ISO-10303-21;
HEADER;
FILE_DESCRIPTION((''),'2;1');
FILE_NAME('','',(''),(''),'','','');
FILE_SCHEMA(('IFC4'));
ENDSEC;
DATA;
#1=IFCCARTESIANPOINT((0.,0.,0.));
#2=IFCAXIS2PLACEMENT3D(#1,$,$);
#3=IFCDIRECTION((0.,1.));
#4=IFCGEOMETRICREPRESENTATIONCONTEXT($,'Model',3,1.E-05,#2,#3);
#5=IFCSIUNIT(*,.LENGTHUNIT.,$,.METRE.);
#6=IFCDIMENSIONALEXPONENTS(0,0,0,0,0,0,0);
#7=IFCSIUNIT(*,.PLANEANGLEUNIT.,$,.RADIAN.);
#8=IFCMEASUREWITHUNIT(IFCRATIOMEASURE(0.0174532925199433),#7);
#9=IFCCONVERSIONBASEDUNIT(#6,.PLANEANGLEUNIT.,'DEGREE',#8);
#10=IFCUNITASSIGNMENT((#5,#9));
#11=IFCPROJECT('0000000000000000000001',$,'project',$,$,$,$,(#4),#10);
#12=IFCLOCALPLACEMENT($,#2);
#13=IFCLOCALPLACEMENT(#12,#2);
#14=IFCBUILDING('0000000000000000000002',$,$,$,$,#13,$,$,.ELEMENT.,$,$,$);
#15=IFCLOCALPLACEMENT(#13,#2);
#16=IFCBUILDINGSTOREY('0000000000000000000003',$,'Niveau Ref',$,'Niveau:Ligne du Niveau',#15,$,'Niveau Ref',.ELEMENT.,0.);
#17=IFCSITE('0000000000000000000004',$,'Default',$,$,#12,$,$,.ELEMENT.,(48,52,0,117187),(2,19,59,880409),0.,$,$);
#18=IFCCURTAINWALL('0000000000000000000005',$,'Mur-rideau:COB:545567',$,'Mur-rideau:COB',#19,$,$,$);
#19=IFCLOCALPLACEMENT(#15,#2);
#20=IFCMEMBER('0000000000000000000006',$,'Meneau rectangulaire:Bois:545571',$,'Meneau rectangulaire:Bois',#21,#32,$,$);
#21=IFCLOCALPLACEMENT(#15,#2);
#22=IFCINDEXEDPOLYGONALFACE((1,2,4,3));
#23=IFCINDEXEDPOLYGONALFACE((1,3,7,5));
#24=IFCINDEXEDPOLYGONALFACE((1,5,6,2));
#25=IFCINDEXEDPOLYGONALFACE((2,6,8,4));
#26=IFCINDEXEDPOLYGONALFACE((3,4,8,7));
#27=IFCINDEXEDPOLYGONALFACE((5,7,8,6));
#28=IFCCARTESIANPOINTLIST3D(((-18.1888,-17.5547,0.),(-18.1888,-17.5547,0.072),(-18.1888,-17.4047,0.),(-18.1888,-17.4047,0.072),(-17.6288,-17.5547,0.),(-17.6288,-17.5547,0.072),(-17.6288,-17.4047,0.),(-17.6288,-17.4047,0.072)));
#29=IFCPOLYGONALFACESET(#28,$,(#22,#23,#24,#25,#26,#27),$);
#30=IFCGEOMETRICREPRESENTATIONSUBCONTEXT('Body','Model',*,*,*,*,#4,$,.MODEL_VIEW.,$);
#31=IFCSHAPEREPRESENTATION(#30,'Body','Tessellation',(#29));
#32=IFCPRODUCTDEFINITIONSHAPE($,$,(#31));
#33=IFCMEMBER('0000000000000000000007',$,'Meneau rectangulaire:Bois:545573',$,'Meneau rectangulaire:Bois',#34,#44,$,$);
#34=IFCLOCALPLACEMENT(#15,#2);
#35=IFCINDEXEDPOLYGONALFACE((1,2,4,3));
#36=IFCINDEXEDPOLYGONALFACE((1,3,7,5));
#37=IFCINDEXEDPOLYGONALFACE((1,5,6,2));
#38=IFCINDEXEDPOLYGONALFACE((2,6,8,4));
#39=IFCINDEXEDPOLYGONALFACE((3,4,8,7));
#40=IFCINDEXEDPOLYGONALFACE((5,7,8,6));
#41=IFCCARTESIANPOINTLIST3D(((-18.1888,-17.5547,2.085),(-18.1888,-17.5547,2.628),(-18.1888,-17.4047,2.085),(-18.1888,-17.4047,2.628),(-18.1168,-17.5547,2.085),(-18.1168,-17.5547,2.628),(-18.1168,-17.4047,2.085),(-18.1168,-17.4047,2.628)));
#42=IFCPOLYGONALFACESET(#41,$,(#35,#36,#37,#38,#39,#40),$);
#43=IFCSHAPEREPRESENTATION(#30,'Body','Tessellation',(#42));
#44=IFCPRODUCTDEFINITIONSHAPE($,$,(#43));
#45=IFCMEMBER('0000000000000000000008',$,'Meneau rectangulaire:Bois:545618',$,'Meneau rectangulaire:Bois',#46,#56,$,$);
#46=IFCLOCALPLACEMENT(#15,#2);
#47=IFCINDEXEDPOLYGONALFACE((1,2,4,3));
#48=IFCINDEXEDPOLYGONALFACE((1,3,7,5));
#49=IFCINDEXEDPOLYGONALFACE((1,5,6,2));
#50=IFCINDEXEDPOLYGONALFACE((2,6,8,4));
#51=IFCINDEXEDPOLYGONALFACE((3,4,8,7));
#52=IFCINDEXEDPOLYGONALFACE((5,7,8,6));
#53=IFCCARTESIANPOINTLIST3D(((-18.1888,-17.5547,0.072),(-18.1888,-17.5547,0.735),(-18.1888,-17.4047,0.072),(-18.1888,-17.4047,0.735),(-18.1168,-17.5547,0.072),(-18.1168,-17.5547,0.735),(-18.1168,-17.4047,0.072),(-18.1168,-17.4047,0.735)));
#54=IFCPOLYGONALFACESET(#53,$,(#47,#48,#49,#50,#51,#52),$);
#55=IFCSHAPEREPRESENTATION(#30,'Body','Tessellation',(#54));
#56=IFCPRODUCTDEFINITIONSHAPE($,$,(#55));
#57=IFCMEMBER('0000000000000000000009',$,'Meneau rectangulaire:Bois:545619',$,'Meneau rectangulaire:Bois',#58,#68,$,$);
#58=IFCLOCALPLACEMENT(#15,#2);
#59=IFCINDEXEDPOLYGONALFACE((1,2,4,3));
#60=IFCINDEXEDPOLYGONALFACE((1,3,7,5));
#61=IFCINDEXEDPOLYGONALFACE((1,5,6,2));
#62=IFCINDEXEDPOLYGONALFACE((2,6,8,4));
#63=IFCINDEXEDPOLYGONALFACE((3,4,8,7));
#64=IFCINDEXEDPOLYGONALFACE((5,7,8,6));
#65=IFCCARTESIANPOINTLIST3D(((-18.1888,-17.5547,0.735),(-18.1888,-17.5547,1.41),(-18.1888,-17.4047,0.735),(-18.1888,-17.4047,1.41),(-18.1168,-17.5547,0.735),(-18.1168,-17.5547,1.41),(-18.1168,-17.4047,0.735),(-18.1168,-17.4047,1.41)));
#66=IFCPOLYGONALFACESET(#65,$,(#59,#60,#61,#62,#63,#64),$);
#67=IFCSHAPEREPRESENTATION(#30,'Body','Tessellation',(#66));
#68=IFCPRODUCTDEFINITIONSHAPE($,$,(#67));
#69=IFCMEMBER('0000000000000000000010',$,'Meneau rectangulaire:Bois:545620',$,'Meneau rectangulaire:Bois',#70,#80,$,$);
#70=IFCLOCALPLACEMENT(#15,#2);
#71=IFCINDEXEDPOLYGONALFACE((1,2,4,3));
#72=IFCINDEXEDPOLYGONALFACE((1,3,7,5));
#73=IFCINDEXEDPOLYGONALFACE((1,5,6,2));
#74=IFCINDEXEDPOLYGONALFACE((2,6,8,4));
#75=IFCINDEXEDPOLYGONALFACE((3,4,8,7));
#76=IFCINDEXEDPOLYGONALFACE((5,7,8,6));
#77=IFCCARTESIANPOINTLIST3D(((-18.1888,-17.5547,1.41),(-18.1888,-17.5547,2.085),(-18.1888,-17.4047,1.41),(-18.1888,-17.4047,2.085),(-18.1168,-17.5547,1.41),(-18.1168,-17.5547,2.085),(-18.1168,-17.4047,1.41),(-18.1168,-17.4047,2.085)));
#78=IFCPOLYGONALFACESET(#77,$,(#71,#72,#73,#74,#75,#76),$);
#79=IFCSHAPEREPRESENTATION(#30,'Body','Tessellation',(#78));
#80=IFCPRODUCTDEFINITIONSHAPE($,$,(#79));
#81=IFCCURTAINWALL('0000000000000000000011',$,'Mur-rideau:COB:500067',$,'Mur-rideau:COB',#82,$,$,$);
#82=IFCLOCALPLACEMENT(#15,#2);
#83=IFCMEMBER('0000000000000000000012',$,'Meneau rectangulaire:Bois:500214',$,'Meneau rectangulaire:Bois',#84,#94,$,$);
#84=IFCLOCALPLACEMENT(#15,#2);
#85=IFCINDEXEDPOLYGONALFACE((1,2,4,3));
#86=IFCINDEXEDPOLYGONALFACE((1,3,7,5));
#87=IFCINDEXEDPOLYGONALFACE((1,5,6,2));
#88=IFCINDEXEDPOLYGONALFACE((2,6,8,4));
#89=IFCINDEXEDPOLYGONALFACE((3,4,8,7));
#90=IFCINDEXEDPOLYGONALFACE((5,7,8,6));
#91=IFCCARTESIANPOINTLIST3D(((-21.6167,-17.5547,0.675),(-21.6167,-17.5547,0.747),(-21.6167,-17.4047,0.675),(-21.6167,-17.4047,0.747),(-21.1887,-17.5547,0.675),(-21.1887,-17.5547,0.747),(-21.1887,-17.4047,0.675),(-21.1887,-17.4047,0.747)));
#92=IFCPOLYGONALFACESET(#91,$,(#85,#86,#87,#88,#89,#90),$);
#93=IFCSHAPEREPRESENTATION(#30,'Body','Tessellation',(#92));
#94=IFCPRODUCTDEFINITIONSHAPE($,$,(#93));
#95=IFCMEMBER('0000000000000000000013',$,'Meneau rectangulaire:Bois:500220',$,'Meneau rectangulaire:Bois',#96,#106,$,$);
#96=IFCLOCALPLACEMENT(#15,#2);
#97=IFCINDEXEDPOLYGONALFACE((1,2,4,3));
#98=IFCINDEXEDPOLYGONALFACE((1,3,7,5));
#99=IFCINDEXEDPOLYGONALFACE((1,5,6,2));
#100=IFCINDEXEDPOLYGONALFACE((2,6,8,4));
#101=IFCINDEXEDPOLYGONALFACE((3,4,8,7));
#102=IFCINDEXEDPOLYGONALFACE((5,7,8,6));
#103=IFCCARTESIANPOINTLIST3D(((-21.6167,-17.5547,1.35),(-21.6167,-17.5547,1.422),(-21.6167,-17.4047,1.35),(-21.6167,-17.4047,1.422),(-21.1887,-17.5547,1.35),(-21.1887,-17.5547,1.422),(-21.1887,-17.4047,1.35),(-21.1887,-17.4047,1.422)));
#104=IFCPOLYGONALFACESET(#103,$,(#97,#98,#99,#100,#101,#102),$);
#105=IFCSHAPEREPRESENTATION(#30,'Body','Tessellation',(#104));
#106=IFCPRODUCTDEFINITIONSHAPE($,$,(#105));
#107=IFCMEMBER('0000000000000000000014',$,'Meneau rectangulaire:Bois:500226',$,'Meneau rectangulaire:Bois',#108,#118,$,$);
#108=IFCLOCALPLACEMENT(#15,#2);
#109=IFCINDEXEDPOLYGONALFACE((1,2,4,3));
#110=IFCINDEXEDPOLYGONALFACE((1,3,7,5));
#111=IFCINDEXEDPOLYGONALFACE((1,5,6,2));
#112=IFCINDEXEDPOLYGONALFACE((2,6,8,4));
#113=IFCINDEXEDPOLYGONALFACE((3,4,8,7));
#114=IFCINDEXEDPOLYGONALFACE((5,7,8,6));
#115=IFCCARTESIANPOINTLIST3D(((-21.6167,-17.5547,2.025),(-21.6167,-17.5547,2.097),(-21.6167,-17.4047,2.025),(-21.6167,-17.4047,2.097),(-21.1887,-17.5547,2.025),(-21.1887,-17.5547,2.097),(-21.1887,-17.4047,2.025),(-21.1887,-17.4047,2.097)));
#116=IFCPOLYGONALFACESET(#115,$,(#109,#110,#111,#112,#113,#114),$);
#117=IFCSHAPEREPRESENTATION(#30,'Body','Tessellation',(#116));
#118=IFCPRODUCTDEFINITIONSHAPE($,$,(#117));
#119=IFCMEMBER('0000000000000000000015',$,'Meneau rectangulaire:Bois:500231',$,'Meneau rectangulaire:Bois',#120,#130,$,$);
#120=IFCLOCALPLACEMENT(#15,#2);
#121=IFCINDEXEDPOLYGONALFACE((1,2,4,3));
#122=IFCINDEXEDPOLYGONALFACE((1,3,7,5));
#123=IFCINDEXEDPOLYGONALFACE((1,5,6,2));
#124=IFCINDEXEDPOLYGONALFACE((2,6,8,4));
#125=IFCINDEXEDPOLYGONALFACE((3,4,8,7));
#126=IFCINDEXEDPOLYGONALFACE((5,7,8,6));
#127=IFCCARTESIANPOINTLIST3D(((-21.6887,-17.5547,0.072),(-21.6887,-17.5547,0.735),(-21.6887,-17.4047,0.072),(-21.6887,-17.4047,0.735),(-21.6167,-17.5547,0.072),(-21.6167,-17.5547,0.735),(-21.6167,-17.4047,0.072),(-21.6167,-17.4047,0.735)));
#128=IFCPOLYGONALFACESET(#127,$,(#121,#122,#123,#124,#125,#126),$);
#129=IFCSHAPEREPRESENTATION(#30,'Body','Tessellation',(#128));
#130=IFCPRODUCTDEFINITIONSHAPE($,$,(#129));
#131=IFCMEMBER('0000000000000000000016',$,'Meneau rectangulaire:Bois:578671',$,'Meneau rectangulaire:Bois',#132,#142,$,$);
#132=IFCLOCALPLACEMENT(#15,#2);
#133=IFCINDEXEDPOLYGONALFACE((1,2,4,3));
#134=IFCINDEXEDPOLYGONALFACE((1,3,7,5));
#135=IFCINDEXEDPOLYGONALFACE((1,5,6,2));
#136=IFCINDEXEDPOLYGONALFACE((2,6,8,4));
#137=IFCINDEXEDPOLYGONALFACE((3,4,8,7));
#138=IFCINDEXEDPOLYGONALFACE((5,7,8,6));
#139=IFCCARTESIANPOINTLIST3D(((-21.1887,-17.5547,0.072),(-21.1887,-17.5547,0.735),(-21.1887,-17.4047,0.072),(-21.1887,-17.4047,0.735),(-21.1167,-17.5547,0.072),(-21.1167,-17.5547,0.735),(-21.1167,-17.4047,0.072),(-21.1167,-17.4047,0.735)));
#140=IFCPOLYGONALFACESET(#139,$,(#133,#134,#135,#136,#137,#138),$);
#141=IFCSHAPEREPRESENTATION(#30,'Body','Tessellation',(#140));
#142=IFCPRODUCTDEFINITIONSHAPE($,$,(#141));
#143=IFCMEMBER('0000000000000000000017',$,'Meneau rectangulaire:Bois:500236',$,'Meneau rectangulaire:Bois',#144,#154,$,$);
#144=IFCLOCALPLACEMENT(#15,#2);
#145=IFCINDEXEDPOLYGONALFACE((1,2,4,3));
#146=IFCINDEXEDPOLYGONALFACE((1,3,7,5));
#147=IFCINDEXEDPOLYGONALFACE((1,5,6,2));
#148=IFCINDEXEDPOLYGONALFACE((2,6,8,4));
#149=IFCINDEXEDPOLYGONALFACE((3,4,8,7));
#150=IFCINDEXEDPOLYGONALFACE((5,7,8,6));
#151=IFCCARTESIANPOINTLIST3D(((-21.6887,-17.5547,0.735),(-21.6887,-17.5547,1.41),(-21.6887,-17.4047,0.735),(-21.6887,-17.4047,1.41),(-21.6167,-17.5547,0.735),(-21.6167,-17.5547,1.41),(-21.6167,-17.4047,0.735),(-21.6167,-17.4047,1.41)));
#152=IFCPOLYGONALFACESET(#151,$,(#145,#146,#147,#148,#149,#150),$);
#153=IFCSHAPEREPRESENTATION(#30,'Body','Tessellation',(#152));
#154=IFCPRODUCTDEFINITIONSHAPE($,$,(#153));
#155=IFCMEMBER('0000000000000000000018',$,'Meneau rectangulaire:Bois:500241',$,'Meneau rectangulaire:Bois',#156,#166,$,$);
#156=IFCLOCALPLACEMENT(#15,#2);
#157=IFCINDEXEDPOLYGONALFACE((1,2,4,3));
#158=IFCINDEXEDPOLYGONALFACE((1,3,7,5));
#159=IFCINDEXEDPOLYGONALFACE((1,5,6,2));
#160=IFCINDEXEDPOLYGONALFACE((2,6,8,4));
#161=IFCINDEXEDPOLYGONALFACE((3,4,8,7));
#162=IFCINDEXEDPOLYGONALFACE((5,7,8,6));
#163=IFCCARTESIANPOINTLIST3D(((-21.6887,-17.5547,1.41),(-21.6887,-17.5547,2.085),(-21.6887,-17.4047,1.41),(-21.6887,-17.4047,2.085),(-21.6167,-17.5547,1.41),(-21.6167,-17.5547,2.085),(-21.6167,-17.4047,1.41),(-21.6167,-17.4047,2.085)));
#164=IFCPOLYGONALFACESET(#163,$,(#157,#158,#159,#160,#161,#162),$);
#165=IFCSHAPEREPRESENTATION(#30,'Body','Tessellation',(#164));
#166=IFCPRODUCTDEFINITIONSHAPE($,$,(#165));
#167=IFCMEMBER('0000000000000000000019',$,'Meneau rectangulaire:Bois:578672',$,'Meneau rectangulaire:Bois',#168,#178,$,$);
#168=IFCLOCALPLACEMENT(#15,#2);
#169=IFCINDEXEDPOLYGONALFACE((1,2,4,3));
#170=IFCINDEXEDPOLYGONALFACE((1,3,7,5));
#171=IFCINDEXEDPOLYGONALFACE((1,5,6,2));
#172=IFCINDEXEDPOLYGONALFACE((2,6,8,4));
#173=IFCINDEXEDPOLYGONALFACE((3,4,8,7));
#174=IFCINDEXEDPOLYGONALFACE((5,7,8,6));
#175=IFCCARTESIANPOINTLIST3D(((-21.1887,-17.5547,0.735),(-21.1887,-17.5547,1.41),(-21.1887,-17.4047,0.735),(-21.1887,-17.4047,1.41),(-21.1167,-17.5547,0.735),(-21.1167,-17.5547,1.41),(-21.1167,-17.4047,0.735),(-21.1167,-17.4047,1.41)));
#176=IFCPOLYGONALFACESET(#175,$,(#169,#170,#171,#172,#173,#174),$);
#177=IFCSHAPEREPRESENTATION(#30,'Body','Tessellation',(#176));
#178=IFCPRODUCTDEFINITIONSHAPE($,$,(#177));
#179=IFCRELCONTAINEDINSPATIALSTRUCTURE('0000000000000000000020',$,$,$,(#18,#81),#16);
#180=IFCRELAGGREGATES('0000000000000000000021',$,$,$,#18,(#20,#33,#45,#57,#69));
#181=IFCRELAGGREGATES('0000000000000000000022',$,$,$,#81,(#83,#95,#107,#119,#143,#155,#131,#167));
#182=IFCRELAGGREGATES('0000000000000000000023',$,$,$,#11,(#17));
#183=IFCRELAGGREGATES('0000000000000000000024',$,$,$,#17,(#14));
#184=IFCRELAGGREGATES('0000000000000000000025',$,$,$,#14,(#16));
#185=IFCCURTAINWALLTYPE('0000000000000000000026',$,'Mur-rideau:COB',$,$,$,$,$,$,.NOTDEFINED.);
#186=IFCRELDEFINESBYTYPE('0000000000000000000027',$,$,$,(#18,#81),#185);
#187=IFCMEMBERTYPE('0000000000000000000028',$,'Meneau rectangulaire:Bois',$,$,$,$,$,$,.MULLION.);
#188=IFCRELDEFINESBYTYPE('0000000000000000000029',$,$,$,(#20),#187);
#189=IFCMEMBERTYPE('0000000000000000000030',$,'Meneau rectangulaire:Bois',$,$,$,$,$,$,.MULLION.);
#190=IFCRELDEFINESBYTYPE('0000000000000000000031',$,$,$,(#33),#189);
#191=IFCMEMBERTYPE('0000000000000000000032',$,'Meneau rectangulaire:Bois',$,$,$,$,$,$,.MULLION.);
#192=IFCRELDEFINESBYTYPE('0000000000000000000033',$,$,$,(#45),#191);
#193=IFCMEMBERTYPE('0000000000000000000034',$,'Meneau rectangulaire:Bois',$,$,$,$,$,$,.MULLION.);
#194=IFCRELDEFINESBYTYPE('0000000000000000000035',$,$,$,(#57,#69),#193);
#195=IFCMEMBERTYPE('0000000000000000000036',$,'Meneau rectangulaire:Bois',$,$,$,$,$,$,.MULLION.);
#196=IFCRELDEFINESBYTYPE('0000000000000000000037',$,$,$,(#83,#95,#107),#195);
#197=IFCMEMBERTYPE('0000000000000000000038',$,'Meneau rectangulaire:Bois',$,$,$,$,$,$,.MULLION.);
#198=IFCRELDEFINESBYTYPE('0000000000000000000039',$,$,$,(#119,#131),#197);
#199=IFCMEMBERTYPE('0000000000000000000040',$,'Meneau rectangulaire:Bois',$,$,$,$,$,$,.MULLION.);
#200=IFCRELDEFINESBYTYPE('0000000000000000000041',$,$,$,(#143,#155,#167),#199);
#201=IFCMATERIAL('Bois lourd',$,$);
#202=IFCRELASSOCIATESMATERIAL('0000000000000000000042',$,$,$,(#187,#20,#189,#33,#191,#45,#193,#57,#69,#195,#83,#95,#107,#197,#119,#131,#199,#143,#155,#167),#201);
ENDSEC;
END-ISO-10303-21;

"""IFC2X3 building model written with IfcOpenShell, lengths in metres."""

from ifc_helpers import new_model, entity, si_unit, converted_unit, direction, frame, origin, origin_2d_with_axis, place, context, subcontext, project, spatial, rectangle, extrude, source, transform, mapped, material, type_object, type_shapes, element, aggregate, save


model = new_model("IFC2X3")

# Units and contexts
model_context = context("Model", 3, precision=1e-05, world=origin(), true_north=direction((0.0, 1.0)))
body_context = subcontext(model_context, "Body", "Model", "MODEL_VIEW")
ifc_project = project(units=[si_unit("LENGTHUNIT", "METRE"), converted_unit("PLANEANGLEUNIT", "DEGREE", entity("IfcRatioMeasure", 0.0174532925199433), si_unit("PLANEANGLEUNIT", "RADIAN"), dimensions=[0, 0, 0, 0, 0, 0, 0])], contexts=[model_context])

# Site, building, storey
site_placement = place(None, origin())
site = spatial("IfcSite", under=ifc_project, at=site_placement, Name="Default", CompositionType="ELEMENT", RefLatitude=(48, 52, 0, 117187), RefLongitude=(2, 19, 59, 880409), RefElevation=0.0)
building_placement = place(site_placement, origin())
building = spatial("IfcBuilding", under=site, at=building_placement, CompositionType="ELEMENT")
storey_placement = place(building_placement, origin())
storey = spatial("IfcBuildingStorey", under=building, at=storey_placement, Name="Niveau Ref", ObjectType="Niveau:Ligne du Niveau", LongName="Niveau Ref", CompositionType="ELEMENT", Elevation=0.0)

# Curtain walls, members
curtain_wall_type_1 = type_object("IfcCurtainWallType", Name="Mur-rideau:COB", PredefinedType="NOTDEFINED")
curtain_wall_1_placement = place(storey_placement, origin())
curtain_wall_1 = element("IfcCurtainWall", 1, at=curtain_wall_1_placement, inside=storey, type_object=curtain_wall_type_1, Name="Mur-rideau:COB:545567", ObjectType="Mur-rideau:COB")
ifc_material_1 = material(Name="Bois lourd")
member_type_1 = type_object("IfcMemberType", Name="Meneau rectangulaire:Bois", PredefinedType="MULLION", material=ifc_material_1)
shared_shape_1 = source(origin(), body_context, "Body", "SweptSolid", [
    extrude(rectangle(XDim=0.15, YDim=0.072, at=origin_2d_with_axis()), frame((-0.036, 0.0, -0.56), z_axis=(0.0, 0.0, 1.0), x_axis=(0.0, -1.0, 0.0)), (0.0, 0.0, 1.0), 0.56),
])
type_shapes(member_type_1, [shared_shape_1])
member_1_placement = place(storey_placement, frame((-18.1888, -17.4797, 0.0), z_axis=(-1.0, 0.0, 0.0), x_axis=(0.0, 0.0, -1.0)))
member_1 = element("IfcMember", 2, at=member_1_placement, type_object=member_type_1, material=ifc_material_1, Name="Meneau rectangulaire:Bois:545571", ObjectType="Meneau rectangulaire:Bois", context=body_context, shape_type="MappedRepresentation", body=[
    mapped(shared_shape_1, transform((0.0, 0.0, 0.0), scale=1.0)),
])
member_type_2 = type_object("IfcMemberType", Name="Meneau rectangulaire:Bois", PredefinedType="MULLION", material=ifc_material_1)
shared_shape_2 = source(origin(), body_context, "Body", "SweptSolid", [
    extrude(rectangle(XDim=0.15, YDim=0.072, at=origin_2d_with_axis()), frame((-0.036, 0.0, -0.543), z_axis=(0.0, 0.0, 1.0), x_axis=(0.0, -1.0, 0.0)), (0.0, 0.0, 1.0), 0.543),
])
type_shapes(member_type_2, [shared_shape_2])
member_2_placement = place(storey_placement, frame((-18.1888, -17.4797, 2.628), z_axis=(0.0, 0.0, 1.0), x_axis=(-1.0, 0.0, 0.0)))
member_2 = element("IfcMember", 3, at=member_2_placement, type_object=member_type_2, material=ifc_material_1, Name="Meneau rectangulaire:Bois:545573", ObjectType="Meneau rectangulaire:Bois", context=body_context, shape_type="MappedRepresentation", body=[
    mapped(shared_shape_2, transform((0.0, 0.0, 0.0), scale=1.0)),
])
member_type_3 = type_object("IfcMemberType", Name="Meneau rectangulaire:Bois", PredefinedType="MULLION", material=ifc_material_1)
shared_shape_3 = source(origin(), body_context, "Body", "SweptSolid", [
    extrude(rectangle(XDim=0.15, YDim=0.072, at=origin_2d_with_axis()), frame((-0.036, 0.0, -0.663), z_axis=(0.0, 0.0, 1.0), x_axis=(0.0, -1.0, 0.0)), (0.0, 0.0, 1.0), 0.663),
])
type_shapes(member_type_3, [shared_shape_3])
member_3_placement = place(storey_placement, frame((-18.1888, -17.4797, 0.735), z_axis=(0.0, 0.0, 1.0), x_axis=(-1.0, 0.0, 0.0)))
member_3 = element("IfcMember", 4, at=member_3_placement, type_object=member_type_3, material=ifc_material_1, Name="Meneau rectangulaire:Bois:545618", ObjectType="Meneau rectangulaire:Bois", context=body_context, shape_type="MappedRepresentation", body=[
    mapped(shared_shape_3, transform((0.0, 0.0, 0.0), scale=1.0)),
])
member_type_4 = type_object("IfcMemberType", Name="Meneau rectangulaire:Bois", PredefinedType="MULLION", material=ifc_material_1)
shared_shape_4 = source(origin(), body_context, "Body", "SweptSolid", [
    extrude(rectangle(XDim=0.15, YDim=0.072, at=origin_2d_with_axis()), frame((-0.036, 0.0, -0.675), z_axis=(0.0, 0.0, 1.0), x_axis=(0.0, -1.0, 0.0)), (0.0, 0.0, 1.0), 0.675),
])
type_shapes(member_type_4, [shared_shape_4])
member_4_placement = place(storey_placement, frame((-18.1888, -17.4797, 1.41), z_axis=(0.0, 0.0, 1.0), x_axis=(-1.0, 0.0, 0.0)))
member_4 = element("IfcMember", 5, at=member_4_placement, type_object=member_type_4, material=ifc_material_1, Name="Meneau rectangulaire:Bois:545619", ObjectType="Meneau rectangulaire:Bois", context=body_context, shape_type="MappedRepresentation", body=[
    mapped(shared_shape_4, transform((0.0, 0.0, 0.0), scale=1.0)),
])
member_5_placement = place(storey_placement, frame((-18.1888, -17.4797, 2.085), z_axis=(0.0, 0.0, 1.0), x_axis=(-1.0, 0.0, 0.0)))
member_5 = element("IfcMember", 6, at=member_5_placement, type_object=member_type_4, material=ifc_material_1, Name="Meneau rectangulaire:Bois:545620", ObjectType="Meneau rectangulaire:Bois", context=body_context, shape_type="MappedRepresentation", body=[
    mapped(shared_shape_4, transform((0.0, 0.0, 0.0), scale=1.0)),
])
aggregate(curtain_wall_1, [member_1, member_2, member_3, member_4, member_5])
curtain_wall_2_placement = place(storey_placement, origin())
curtain_wall_2 = element("IfcCurtainWall", 7, at=curtain_wall_2_placement, inside=storey, type_object=curtain_wall_type_1, Name="Mur-rideau:COB:500067", ObjectType="Mur-rideau:COB")
member_type_5 = type_object("IfcMemberType", Name="Meneau rectangulaire:Bois", PredefinedType="MULLION", material=ifc_material_1)
shared_shape_5 = source(origin(), body_context, "Body", "SweptSolid", [
    extrude(rectangle(XDim=0.15, YDim=0.072, at=origin_2d_with_axis()), frame((-0.024, 0.0, -0.428), z_axis=(0.0, 0.0, 1.0), x_axis=(0.0, -1.0, 0.0)), (0.0, 0.0, 1.0), 0.428),
])
type_shapes(member_type_5, [shared_shape_5])
member_6_placement = place(storey_placement, frame((-21.1887, -17.4797, 0.735), z_axis=(1.0, 0.0, 0.0), x_axis=(0.0, 0.0, 1.0)))
member_6 = element("IfcMember", 8, at=member_6_placement, type_object=member_type_5, material=ifc_material_1, Name="Meneau rectangulaire:Bois:500214", ObjectType="Meneau rectangulaire:Bois", context=body_context, shape_type="MappedRepresentation", body=[
    mapped(shared_shape_5, transform((0.0, 0.0, 0.0), scale=1.0)),
])
member_7_placement = place(storey_placement, frame((-21.1887, -17.4797, 1.41), z_axis=(1.0, 0.0, 0.0), x_axis=(0.0, 0.0, 1.0)))
member_7 = element("IfcMember", 9, at=member_7_placement, type_object=member_type_5, material=ifc_material_1, Name="Meneau rectangulaire:Bois:500220", ObjectType="Meneau rectangulaire:Bois", context=body_context, shape_type="MappedRepresentation", body=[
    mapped(shared_shape_5, transform((0.0, 0.0, 0.0), scale=1.0)),
])
member_8_placement = place(storey_placement, frame((-21.1887, -17.4797, 2.085), z_axis=(1.0, 0.0, 0.0), x_axis=(0.0, 0.0, 1.0)))
member_8 = element("IfcMember", 10, at=member_8_placement, type_object=member_type_5, material=ifc_material_1, Name="Meneau rectangulaire:Bois:500226", ObjectType="Meneau rectangulaire:Bois", context=body_context, shape_type="MappedRepresentation", body=[
    mapped(shared_shape_5, transform((0.0, 0.0, 0.0), scale=1.0)),
])
member_type_6 = type_object("IfcMemberType", Name="Meneau rectangulaire:Bois", PredefinedType="MULLION", material=ifc_material_1)
shared_shape_6 = source(origin(), body_context, "Body", "SweptSolid", [
    extrude(rectangle(XDim=0.15, YDim=0.072, at=origin_2d_with_axis()), frame((-0.024, 0.0, -0.663), z_axis=(0.0, 0.0, 1.0), x_axis=(0.0, -1.0, 0.0)), (0.0, 0.0, 1.0), 0.663),
])
type_shapes(member_type_6, [shared_shape_6])
member_9_placement = place(storey_placement, frame((-21.6287, -17.4797, 0.072), z_axis=(0.0, 0.0, -1.0), x_axis=(1.0, 0.0, 0.0)))
member_9 = element("IfcMember", 11, at=member_9_placement, type_object=member_type_6, material=ifc_material_1, Name="Meneau rectangulaire:Bois:500231", ObjectType="Meneau rectangulaire:Bois", context=body_context, shape_type="MappedRepresentation", body=[
    mapped(shared_shape_6, transform((0.0, 0.0, 0.0), scale=1.0)),
])
member_10_placement = place(storey_placement, frame((-21.1287, -17.4797, 0.072), z_axis=(0.0, 0.0, -1.0), x_axis=(1.0, 0.0, 0.0)))
member_10 = element("IfcMember", 12, at=member_10_placement, type_object=member_type_6, material=ifc_material_1, Name="Meneau rectangulaire:Bois:578671", ObjectType="Meneau rectangulaire:Bois", context=body_context, shape_type="MappedRepresentation", body=[
    mapped(shared_shape_6, transform((0.0, 0.0, 0.0), scale=1.0)),
])
member_type_7 = type_object("IfcMemberType", Name="Meneau rectangulaire:Bois", PredefinedType="MULLION", material=ifc_material_1)
shared_shape_7 = source(origin(), body_context, "Body", "SweptSolid", [
    extrude(rectangle(XDim=0.15, YDim=0.072, at=origin_2d_with_axis()), frame((-0.024, 0.0, -0.675), z_axis=(0.0, 0.0, 1.0), x_axis=(0.0, -1.0, 0.0)), (0.0, 0.0, 1.0), 0.675),
])
type_shapes(member_type_7, [shared_shape_7])
member_11_placement = place(storey_placement, frame((-21.6287, -17.4797, 0.735), z_axis=(0.0, 0.0, -1.0), x_axis=(1.0, 0.0, 0.0)))
member_11 = element("IfcMember", 13, at=member_11_placement, type_object=member_type_7, material=ifc_material_1, Name="Meneau rectangulaire:Bois:500236", ObjectType="Meneau rectangulaire:Bois", context=body_context, shape_type="MappedRepresentation", body=[
    mapped(shared_shape_7, transform((0.0, 0.0, 0.0), scale=1.0)),
])
member_12_placement = place(storey_placement, frame((-21.6287, -17.4797, 1.41), z_axis=(0.0, 0.0, -1.0), x_axis=(1.0, 0.0, 0.0)))
member_12 = element("IfcMember", 14, at=member_12_placement, type_object=member_type_7, material=ifc_material_1, Name="Meneau rectangulaire:Bois:500241", ObjectType="Meneau rectangulaire:Bois", context=body_context, shape_type="MappedRepresentation", body=[
    mapped(shared_shape_7, transform((0.0, 0.0, 0.0), scale=1.0)),
])
member_13_placement = place(storey_placement, frame((-21.1287, -17.4797, 0.735), z_axis=(0.0, 0.0, -1.0), x_axis=(1.0, 0.0, 0.0)))
member_13 = element("IfcMember", 15, at=member_13_placement, type_object=member_type_7, material=ifc_material_1, Name="Meneau rectangulaire:Bois:578672", ObjectType="Meneau rectangulaire:Bois", context=body_context, shape_type="MappedRepresentation", body=[
    mapped(shared_shape_7, transform((0.0, 0.0, 0.0), scale=1.0)),
])
aggregate(curtain_wall_2, [member_6, member_7, member_8, member_9, member_11, member_12, member_10, member_13])

save(model, "model.ifc")
